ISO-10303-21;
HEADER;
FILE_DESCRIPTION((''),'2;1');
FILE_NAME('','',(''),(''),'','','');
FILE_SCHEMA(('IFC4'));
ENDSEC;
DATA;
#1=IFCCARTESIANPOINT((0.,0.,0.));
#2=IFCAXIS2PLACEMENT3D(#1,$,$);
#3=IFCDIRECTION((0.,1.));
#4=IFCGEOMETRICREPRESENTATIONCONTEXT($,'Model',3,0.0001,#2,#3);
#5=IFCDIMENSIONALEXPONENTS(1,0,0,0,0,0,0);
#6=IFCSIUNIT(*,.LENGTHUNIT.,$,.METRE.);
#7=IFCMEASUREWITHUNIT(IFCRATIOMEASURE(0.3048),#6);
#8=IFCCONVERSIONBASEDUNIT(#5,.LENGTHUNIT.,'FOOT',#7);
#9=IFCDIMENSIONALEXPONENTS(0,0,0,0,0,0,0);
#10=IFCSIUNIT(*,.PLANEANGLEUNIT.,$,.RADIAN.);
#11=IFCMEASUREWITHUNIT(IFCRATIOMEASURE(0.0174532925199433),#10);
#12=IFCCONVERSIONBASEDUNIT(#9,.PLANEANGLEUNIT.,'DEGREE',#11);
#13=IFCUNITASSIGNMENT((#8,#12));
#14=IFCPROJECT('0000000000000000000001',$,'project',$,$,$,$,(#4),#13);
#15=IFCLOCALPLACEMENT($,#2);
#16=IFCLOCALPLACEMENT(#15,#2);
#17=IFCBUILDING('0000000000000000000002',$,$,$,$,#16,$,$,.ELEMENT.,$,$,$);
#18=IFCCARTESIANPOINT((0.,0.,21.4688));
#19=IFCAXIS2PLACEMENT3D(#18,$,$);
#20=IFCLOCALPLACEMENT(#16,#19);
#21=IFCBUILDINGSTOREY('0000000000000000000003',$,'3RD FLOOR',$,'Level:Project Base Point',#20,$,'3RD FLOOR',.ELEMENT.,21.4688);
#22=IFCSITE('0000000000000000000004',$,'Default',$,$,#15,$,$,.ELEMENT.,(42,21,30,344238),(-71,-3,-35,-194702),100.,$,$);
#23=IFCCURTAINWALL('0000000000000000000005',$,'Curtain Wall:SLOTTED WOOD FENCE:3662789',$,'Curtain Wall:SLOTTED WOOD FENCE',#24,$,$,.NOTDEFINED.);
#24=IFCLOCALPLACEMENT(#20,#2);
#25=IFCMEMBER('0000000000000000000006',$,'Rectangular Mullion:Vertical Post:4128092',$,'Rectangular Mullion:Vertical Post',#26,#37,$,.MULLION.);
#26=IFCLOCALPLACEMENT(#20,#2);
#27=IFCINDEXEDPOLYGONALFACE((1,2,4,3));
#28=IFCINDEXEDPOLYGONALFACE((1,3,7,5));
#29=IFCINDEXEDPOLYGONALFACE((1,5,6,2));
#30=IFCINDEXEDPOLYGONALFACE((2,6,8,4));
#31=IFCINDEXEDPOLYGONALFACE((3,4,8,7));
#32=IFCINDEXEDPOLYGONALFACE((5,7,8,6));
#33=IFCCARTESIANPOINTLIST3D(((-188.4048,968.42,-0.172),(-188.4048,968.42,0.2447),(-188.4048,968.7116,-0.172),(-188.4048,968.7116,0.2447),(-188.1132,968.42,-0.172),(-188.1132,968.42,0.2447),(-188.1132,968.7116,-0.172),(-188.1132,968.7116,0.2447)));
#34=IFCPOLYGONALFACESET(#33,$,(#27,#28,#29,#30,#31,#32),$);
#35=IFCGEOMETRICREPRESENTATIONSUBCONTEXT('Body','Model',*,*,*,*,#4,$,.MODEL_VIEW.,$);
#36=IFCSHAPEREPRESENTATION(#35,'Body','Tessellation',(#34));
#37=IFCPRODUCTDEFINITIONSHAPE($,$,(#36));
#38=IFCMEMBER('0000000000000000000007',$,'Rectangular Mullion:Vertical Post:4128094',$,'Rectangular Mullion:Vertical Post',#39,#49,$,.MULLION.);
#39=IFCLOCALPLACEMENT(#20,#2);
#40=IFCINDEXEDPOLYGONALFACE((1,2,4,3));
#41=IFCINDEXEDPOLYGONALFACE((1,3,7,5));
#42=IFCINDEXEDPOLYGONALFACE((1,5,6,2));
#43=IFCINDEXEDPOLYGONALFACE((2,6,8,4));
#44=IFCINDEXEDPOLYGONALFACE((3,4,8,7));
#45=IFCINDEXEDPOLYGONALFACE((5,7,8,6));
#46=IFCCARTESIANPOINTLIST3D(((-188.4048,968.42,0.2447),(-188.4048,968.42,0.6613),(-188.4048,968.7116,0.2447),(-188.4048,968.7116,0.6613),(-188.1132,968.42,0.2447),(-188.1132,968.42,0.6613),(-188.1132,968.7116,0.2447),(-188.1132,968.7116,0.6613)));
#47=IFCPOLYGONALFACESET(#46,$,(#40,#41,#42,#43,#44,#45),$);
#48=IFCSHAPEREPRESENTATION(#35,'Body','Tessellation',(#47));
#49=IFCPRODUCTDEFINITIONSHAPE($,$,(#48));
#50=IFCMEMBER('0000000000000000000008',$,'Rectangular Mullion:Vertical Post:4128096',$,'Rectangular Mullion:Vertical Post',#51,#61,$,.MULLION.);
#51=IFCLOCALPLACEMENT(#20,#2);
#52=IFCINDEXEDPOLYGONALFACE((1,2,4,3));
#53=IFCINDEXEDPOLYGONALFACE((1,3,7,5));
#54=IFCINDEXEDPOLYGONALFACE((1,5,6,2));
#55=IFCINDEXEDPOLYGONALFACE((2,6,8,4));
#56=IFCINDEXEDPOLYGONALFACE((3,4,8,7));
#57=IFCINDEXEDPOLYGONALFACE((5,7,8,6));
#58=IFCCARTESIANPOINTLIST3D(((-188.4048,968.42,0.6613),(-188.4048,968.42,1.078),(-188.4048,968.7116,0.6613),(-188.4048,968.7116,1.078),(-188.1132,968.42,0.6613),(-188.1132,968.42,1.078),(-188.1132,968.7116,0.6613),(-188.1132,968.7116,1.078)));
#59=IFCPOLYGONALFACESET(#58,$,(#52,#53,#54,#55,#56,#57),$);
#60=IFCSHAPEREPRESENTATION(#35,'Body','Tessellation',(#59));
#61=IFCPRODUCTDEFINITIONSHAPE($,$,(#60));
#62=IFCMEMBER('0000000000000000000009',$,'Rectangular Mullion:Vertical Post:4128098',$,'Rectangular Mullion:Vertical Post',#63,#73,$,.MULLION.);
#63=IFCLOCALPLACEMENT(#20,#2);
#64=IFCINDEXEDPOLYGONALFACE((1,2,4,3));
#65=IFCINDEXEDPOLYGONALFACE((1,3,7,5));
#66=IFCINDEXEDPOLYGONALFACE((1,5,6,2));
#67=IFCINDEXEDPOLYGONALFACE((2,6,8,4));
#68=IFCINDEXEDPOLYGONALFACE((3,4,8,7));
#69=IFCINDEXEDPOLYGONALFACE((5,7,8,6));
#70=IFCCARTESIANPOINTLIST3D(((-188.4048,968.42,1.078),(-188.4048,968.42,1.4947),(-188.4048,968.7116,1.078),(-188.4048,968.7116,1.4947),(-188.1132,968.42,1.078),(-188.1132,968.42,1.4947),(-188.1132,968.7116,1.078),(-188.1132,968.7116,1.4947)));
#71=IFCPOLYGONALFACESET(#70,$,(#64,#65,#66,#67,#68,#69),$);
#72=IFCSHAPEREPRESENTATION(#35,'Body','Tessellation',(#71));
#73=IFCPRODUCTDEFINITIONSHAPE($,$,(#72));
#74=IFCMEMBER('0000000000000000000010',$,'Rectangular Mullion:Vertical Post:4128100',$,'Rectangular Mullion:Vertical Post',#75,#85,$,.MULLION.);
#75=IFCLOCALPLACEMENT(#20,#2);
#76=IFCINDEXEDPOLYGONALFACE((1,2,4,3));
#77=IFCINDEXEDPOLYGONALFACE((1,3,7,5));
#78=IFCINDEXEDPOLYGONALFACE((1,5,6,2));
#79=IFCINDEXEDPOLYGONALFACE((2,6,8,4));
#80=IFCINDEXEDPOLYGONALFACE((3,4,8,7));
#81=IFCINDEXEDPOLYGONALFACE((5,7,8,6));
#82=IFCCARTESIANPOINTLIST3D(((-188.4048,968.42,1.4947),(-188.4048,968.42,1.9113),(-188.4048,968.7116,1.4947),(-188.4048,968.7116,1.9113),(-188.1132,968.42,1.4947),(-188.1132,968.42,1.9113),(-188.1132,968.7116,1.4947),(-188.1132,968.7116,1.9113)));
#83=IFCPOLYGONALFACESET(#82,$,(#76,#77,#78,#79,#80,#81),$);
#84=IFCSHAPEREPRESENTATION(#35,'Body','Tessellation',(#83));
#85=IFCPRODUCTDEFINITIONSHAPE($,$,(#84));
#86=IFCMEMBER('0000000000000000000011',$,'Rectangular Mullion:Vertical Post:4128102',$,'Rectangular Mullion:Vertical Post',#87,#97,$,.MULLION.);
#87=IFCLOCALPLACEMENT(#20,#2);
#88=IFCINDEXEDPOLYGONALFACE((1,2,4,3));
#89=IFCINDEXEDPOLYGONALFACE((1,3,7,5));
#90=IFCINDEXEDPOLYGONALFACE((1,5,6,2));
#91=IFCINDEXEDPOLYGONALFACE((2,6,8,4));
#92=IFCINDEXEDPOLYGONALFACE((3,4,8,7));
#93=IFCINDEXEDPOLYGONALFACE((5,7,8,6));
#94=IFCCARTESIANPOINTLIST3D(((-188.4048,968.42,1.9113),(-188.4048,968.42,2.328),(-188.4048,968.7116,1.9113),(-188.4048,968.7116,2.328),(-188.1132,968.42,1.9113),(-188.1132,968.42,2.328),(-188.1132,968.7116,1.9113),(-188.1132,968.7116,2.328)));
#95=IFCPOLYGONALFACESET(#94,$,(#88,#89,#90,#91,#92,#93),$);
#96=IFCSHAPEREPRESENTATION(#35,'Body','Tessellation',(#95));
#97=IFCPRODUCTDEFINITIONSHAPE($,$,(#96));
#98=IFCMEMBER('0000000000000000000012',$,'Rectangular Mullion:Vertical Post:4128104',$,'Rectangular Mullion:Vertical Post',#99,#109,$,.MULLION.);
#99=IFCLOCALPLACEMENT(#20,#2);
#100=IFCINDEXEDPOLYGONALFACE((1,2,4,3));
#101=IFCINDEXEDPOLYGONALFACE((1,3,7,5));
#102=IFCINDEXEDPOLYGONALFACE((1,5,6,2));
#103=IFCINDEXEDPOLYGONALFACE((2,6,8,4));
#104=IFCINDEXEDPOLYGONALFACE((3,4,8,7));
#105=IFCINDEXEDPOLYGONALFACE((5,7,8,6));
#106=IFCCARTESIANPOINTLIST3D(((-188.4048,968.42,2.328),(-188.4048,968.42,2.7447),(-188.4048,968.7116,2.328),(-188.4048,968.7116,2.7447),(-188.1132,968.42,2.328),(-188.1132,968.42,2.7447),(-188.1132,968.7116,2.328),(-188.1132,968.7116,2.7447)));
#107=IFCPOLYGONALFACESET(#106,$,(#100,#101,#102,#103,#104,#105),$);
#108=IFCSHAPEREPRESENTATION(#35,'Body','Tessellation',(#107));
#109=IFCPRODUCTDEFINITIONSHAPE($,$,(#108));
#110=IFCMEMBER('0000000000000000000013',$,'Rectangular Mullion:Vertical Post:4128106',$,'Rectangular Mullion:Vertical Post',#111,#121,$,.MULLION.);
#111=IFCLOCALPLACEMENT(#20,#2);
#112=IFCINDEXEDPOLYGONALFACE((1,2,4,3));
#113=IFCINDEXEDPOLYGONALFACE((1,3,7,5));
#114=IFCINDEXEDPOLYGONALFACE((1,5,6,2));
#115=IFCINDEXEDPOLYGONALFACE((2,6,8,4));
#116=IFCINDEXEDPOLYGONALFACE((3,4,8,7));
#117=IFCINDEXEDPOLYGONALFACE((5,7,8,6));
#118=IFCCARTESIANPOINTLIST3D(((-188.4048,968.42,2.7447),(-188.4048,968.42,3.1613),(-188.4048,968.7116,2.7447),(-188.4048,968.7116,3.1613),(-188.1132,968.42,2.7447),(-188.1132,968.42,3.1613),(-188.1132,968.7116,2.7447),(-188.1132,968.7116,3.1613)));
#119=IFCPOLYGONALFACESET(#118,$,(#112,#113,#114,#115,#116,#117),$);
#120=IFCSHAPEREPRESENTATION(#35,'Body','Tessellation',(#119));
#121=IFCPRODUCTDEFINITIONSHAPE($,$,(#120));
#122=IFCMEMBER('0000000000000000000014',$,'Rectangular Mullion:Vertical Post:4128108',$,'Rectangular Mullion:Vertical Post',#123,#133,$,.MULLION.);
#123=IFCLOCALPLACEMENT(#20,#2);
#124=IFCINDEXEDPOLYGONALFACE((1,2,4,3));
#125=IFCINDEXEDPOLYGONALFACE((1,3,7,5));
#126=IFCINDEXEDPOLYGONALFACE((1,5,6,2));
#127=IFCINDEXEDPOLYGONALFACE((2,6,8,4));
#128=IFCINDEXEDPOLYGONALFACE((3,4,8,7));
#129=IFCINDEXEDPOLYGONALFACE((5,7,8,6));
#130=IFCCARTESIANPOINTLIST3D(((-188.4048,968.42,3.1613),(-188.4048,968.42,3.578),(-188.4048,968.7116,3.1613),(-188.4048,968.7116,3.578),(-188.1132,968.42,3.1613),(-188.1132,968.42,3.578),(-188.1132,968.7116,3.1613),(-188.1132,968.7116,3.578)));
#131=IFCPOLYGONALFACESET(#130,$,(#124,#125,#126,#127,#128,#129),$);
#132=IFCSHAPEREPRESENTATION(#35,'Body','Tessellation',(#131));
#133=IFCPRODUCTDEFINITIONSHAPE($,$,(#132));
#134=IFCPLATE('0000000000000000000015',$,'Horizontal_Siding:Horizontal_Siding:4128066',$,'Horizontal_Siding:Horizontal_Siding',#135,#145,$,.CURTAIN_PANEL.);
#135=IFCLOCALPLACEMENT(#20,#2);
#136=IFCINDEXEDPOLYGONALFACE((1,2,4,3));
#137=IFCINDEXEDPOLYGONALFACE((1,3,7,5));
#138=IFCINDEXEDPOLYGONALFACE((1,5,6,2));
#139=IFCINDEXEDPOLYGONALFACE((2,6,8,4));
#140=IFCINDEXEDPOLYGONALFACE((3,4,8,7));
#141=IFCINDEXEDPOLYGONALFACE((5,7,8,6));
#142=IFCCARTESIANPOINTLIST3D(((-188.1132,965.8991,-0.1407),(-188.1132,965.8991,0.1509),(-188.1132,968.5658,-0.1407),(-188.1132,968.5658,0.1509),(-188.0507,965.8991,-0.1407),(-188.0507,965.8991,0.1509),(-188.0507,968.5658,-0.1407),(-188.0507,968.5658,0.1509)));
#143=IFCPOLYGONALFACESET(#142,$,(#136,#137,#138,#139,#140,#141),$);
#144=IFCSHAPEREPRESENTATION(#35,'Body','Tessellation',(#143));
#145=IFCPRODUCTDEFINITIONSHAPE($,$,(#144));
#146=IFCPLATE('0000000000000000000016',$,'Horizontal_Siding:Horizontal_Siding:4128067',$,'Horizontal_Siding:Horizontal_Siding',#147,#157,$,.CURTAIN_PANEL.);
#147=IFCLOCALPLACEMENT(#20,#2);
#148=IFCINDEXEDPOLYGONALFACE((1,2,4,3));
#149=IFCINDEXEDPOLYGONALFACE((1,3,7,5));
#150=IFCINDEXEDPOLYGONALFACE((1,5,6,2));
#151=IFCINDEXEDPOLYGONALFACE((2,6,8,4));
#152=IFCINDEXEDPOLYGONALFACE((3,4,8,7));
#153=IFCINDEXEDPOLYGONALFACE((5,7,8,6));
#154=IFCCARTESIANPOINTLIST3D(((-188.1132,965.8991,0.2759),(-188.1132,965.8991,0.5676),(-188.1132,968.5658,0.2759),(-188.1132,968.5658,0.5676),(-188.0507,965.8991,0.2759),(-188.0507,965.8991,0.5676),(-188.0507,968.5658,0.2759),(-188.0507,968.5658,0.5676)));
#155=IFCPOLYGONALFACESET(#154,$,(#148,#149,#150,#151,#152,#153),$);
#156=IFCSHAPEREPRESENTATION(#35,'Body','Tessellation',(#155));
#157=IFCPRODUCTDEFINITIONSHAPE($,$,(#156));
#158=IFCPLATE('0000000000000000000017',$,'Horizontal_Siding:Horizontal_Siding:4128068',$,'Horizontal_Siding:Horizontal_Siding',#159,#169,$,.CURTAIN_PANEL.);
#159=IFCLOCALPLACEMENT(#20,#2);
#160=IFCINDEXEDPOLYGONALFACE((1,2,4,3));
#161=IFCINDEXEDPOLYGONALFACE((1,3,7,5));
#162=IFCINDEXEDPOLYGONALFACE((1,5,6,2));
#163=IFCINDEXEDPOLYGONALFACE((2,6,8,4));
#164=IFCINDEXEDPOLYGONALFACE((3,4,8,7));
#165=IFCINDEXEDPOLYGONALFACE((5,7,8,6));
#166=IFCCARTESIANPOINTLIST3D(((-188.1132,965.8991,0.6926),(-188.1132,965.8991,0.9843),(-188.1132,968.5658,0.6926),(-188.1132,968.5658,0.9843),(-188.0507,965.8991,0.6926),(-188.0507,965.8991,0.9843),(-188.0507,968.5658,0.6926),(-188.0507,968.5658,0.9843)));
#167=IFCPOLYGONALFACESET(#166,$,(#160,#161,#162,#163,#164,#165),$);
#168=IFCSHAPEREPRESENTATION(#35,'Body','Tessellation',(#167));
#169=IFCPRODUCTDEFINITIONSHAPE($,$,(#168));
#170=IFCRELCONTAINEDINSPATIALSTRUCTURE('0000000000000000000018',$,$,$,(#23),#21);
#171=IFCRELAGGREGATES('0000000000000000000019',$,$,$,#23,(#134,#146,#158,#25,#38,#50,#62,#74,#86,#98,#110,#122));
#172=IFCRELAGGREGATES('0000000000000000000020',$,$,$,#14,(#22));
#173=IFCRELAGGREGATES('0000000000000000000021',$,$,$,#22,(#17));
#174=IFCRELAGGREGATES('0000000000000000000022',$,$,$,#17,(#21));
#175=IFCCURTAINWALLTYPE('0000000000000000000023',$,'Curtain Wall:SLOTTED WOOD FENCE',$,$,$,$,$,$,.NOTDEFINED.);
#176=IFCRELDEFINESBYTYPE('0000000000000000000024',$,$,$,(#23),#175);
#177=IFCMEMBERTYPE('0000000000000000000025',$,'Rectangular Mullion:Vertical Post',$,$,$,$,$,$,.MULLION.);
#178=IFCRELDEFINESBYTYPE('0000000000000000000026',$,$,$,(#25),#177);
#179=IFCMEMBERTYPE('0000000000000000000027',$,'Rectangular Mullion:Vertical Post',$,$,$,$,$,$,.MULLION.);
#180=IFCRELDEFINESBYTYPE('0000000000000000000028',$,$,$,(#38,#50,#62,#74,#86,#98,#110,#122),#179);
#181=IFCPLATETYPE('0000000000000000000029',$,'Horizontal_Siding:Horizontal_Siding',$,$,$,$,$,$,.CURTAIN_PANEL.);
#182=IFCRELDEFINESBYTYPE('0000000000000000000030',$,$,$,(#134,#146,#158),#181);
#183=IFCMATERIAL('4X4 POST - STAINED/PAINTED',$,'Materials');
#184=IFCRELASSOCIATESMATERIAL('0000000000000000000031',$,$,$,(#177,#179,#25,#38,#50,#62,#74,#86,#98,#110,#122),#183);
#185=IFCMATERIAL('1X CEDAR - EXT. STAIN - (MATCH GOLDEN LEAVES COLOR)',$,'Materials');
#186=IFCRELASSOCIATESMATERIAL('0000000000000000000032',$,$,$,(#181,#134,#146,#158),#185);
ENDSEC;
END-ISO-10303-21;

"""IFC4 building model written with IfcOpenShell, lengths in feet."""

from ifc_helpers import new_model, entity, si_unit, converted_unit, direction, frame, origin, origin_2d_with_axis, place, context, subcontext, project, spatial, rectangle, extrude, source, transform, mapped, material, material_profile, profile_set, profile_usage, type_object, type_shapes, element, aggregate, save


model = new_model("IFC4")

# Units and contexts
model_context = context("Model", 3, precision=0.0001, world=origin(), true_north=direction((0.0, 1.0)))
body_context = subcontext(model_context, "Body", "Model", "MODEL_VIEW")
ifc_project = project(units=[converted_unit("LENGTHUNIT", "FOOT", entity("IfcRatioMeasure", 0.3048), si_unit("LENGTHUNIT", "METRE"), dimensions=[1, 0, 0, 0, 0, 0, 0]), converted_unit("PLANEANGLEUNIT", "DEGREE", entity("IfcRatioMeasure", 0.0174532925199433), si_unit("PLANEANGLEUNIT", "RADIAN"), dimensions=[0, 0, 0, 0, 0, 0, 0])], contexts=[model_context])

# Site, building, storey
site_placement = place(None, origin())
site = spatial("IfcSite", under=ifc_project, at=site_placement, Name="Default", CompositionType="ELEMENT", RefLatitude=(42, 21, 30, 344238), RefLongitude=(-71, -3, -35, -194702), RefElevation=100.0)
building_placement = place(site_placement, origin())
building = spatial("IfcBuilding", under=site, at=building_placement, CompositionType="ELEMENT")
storey_placement = place(building_placement, frame((0.0, 0.0, 21.4688)))
storey = spatial("IfcBuildingStorey", under=building, at=storey_placement, Name="3RD FLOOR", ObjectType="Level:Project Base Point", LongName="3RD FLOOR", CompositionType="ELEMENT", Elevation=21.4688)

# Curtain wall, members, plates
curtain_wall_type = type_object("IfcCurtainWallType", Name="Curtain Wall:SLOTTED WOOD FENCE", PredefinedType="NOTDEFINED")
curtain_wall_placement = place(storey_placement, frame((0.0, 0.0, -21.4688)))
curtain_wall = element("IfcCurtainWall", 1, at=curtain_wall_placement, inside=storey, type_object=curtain_wall_type, Name="Curtain Wall:SLOTTED WOOD FENCE:3662789", ObjectType="Curtain Wall:SLOTTED WOOD FENCE", PredefinedType="NOTDEFINED")
ifc_material_1 = material(Name="4X4 POST - STAINED/PAINTED", Category="Materials")
ifc_material_profile = material_profile(ifc_material_1, rectangle(XDim=0.2917, YDim=0.2917, at=origin_2d_with_axis()), Name="Vertical Post")
ifc_profile_set = profile_set([ifc_material_profile], Name="Vertical Post")
ifc_profile_usage_1 = profile_usage(ifc_profile_set)
member_type_1 = type_object("IfcMemberType", Name="Rectangular Mullion:Vertical Post", PredefinedType="MULLION", material=ifc_profile_set)
shared_shape_1 = source(origin(), body_context, "Body", "SweptSolid", [
    extrude(rectangle(XDim=0.2917, YDim=0.2917, at=origin_2d_with_axis()), frame((0.0, 0.2083, -0.4167), z_axis=(0.0, 0.0, 1.0), x_axis=(0.0, -1.0, 0.0)), (0.0, 0.0, 1.0), 0.4167),
])
type_shapes(member_type_1, [shared_shape_1])
member_1_placement = place(storey_placement, frame((-188.0507, 968.5658, -0.172), z_axis=(0.0, 0.0, -1.0), x_axis=(0.0, -1.0, 0.0)))
member_1 = element("IfcMember", 2, at=member_1_placement, type_object=member_type_1, material=ifc_profile_usage_1, Name="Rectangular Mullion:Vertical Post:4128092", ObjectType="Rectangular Mullion:Vertical Post", PredefinedType="MULLION", context=body_context, shape_type="MappedRepresentation", body=[
    mapped(shared_shape_1, transform((0.0, 0.0, 0.0), scale=1.0)),
])
ifc_profile_usage_2 = profile_usage(ifc_profile_set)
member_type_2 = type_object("IfcMemberType", Name="Rectangular Mullion:Vertical Post", PredefinedType="MULLION", material=ifc_profile_set)
shared_shape_2 = source(origin(), body_context, "Body", "SweptSolid", [
    extrude(rectangle(XDim=0.2917, YDim=0.2917, at=origin_2d_with_axis()), frame((0.0, 0.2083, -0.4167), z_axis=(0.0, 0.0, 1.0), x_axis=(0.0, -1.0, 0.0)), (0.0, 0.0, 1.0), 0.4167),
])
type_shapes(member_type_2, [shared_shape_2])
member_2_placement = place(storey_placement, frame((-188.0507, 968.5658, 0.2447), z_axis=(0.0, 0.0, -1.0), x_axis=(0.0, -1.0, 0.0)))
member_2 = element("IfcMember", 3, at=member_2_placement, type_object=member_type_2, material=ifc_profile_usage_2, Name="Rectangular Mullion:Vertical Post:4128094", ObjectType="Rectangular Mullion:Vertical Post", PredefinedType="MULLION", context=body_context, shape_type="MappedRepresentation", body=[
    mapped(shared_shape_2, transform((0.0, 0.0, 0.0), scale=1.0)),
])
ifc_profile_usage_3 = profile_usage(ifc_profile_set)
member_3_placement = place(storey_placement, frame((-188.0507, 968.5658, 0.6613), z_axis=(0.0, 0.0, -1.0), x_axis=(0.0, -1.0, 0.0)))
member_3 = element("IfcMember", 4, at=member_3_placement, type_object=member_type_2, material=ifc_profile_usage_3, Name="Rectangular Mullion:Vertical Post:4128096", ObjectType="Rectangular Mullion:Vertical Post", PredefinedType="MULLION", context=body_context, shape_type="MappedRepresentation", body=[
    mapped(shared_shape_2, transform((0.0, 0.0, 0.0), scale=1.0)),
])
ifc_profile_usage_4 = profile_usage(ifc_profile_set)
member_4_placement = place(storey_placement, frame((-188.0507, 968.5658, 1.078), z_axis=(0.0, 0.0, -1.0), x_axis=(0.0, -1.0, 0.0)))
member_4 = element("IfcMember", 5, at=member_4_placement, type_object=member_type_2, material=ifc_profile_usage_4, Name="Rectangular Mullion:Vertical Post:4128098", ObjectType="Rectangular Mullion:Vertical Post", PredefinedType="MULLION", context=body_context, shape_type="MappedRepresentation", body=[
    mapped(shared_shape_2, transform((0.0, 0.0, 0.0), scale=1.0)),
])
ifc_profile_usage_5 = profile_usage(ifc_profile_set)
member_5_placement = place(storey_placement, frame((-188.0507, 968.5658, 1.4947), z_axis=(0.0, 0.0, -1.0), x_axis=(0.0, -1.0, 0.0)))
member_5 = element("IfcMember", 6, at=member_5_placement, type_object=member_type_2, material=ifc_profile_usage_5, Name="Rectangular Mullion:Vertical Post:4128100", ObjectType="Rectangular Mullion:Vertical Post", PredefinedType="MULLION", context=body_context, shape_type="MappedRepresentation", body=[
    mapped(shared_shape_2, transform((0.0, 0.0, 0.0), scale=1.0)),
])
ifc_profile_usage_6 = profile_usage(ifc_profile_set)
member_6_placement = place(storey_placement, frame((-188.0507, 968.5658, 1.9113), z_axis=(0.0, 0.0, -1.0), x_axis=(0.0, -1.0, 0.0)))
member_6 = element("IfcMember", 7, at=member_6_placement, type_object=member_type_2, material=ifc_profile_usage_6, Name="Rectangular Mullion:Vertical Post:4128102", ObjectType="Rectangular Mullion:Vertical Post", PredefinedType="MULLION", context=body_context, shape_type="MappedRepresentation", body=[
    mapped(shared_shape_2, transform((0.0, 0.0, 0.0), scale=1.0)),
])
ifc_profile_usage_7 = profile_usage(ifc_profile_set)
member_7_placement = place(storey_placement, frame((-188.0507, 968.5658, 2.328), z_axis=(0.0, 0.0, -1.0), x_axis=(0.0, -1.0, 0.0)))
member_7 = element("IfcMember", 8, at=member_7_placement, type_object=member_type_2, material=ifc_profile_usage_7, Name="Rectangular Mullion:Vertical Post:4128104", ObjectType="Rectangular Mullion:Vertical Post", PredefinedType="MULLION", context=body_context, shape_type="MappedRepresentation", body=[
    mapped(shared_shape_2, transform((0.0, 0.0, 0.0), scale=1.0)),
])
ifc_profile_usage_8 = profile_usage(ifc_profile_set)
member_8_placement = place(storey_placement, frame((-188.0507, 968.5658, 2.7447), z_axis=(0.0, 0.0, -1.0), x_axis=(0.0, -1.0, 0.0)))
member_8 = element("IfcMember", 9, at=member_8_placement, type_object=member_type_2, material=ifc_profile_usage_8, Name="Rectangular Mullion:Vertical Post:4128106", ObjectType="Rectangular Mullion:Vertical Post", PredefinedType="MULLION", context=body_context, shape_type="MappedRepresentation", body=[
    mapped(shared_shape_2, transform((0.0, 0.0, 0.0), scale=1.0)),
])
ifc_profile_usage_9 = profile_usage(ifc_profile_set)
member_9_placement = place(storey_placement, frame((-188.0507, 968.5658, 3.1613), z_axis=(0.0, 0.0, -1.0), x_axis=(0.0, -1.0, 0.0)))
member_9 = element("IfcMember", 10, at=member_9_placement, type_object=member_type_2, material=ifc_profile_usage_9, Name="Rectangular Mullion:Vertical Post:4128108", ObjectType="Rectangular Mullion:Vertical Post", PredefinedType="MULLION", context=body_context, shape_type="MappedRepresentation", body=[
    mapped(shared_shape_2, transform((0.0, 0.0, 0.0), scale=1.0)),
])
ifc_material_2 = material(Name="1X CEDAR - EXT. STAIN - (MATCH GOLDEN LEAVES COLOR)", Category="Materials")
plate_type_1 = type_object("IfcPlateType", Name="Horizontal_Siding:Horizontal_Siding", PredefinedType="CURTAIN_PANEL", material=ifc_material_2)
shared_shape_3 = source(origin(), body_context, "Body", "SweptSolid", [
    extrude(rectangle(XDim=0.0625, YDim=2.6667, at=origin_2d_with_axis()), frame((1.3333, 0.0312, 0.0), z_axis=(0.0, 0.0, 1.0), x_axis=(0.0, 1.0, 0.0)), (0.0, 0.0, 1.0), 0.2917),
])
type_shapes(plate_type_1, [shared_shape_3])
plate_1_placement = place(curtain_wall_placement, frame((-188.1132, 968.5658, 21.328), z_axis=(0.0, 0.0, 1.0), x_axis=(0.0, -1.0, 0.0)))
plate_1 = element("IfcPlate", 11, at=plate_1_placement, type_object=plate_type_1, material=ifc_material_2, Name="Horizontal_Siding:Horizontal_Siding:4128066", ObjectType="Horizontal_Siding:Horizontal_Siding", PredefinedType="CURTAIN_PANEL", context=body_context, shape_type="MappedRepresentation", body=[
    mapped(shared_shape_3, transform((0.0, 0.0, 0.0), scale=1.0)),
])
plate_2_placement = place(curtain_wall_placement, frame((-188.1132, 968.5658, 21.7447), z_axis=(0.0, 0.0, 1.0), x_axis=(0.0, -1.0, 0.0)))
plate_2 = element("IfcPlate", 12, at=plate_2_placement, type_object=plate_type_1, material=ifc_material_2, Name="Horizontal_Siding:Horizontal_Siding:4128067", ObjectType="Horizontal_Siding:Horizontal_Siding", PredefinedType="CURTAIN_PANEL", context=body_context, shape_type="MappedRepresentation", body=[
    mapped(shared_shape_3, transform((0.0, 0.0, 0.0), scale=1.0)),
])
plate_3_placement = place(curtain_wall_placement, frame((-188.1132, 968.5658, 22.1613), z_axis=(0.0, 0.0, 1.0), x_axis=(0.0, -1.0, 0.0)))
plate_3 = element("IfcPlate", 13, at=plate_3_placement, type_object=plate_type_1, material=ifc_material_2, Name="Horizontal_Siding:Horizontal_Siding:4128068", ObjectType="Horizontal_Siding:Horizontal_Siding", PredefinedType="CURTAIN_PANEL", context=body_context, shape_type="MappedRepresentation", body=[
    mapped(shared_shape_3, transform((0.0, 0.0, 0.0), scale=1.0)),
])
aggregate(curtain_wall, [plate_1, plate_2, plate_3, member_1, member_2, member_3, member_4, member_5, member_6, member_7, member_8, member_9])

save(model, "model.ifc")
